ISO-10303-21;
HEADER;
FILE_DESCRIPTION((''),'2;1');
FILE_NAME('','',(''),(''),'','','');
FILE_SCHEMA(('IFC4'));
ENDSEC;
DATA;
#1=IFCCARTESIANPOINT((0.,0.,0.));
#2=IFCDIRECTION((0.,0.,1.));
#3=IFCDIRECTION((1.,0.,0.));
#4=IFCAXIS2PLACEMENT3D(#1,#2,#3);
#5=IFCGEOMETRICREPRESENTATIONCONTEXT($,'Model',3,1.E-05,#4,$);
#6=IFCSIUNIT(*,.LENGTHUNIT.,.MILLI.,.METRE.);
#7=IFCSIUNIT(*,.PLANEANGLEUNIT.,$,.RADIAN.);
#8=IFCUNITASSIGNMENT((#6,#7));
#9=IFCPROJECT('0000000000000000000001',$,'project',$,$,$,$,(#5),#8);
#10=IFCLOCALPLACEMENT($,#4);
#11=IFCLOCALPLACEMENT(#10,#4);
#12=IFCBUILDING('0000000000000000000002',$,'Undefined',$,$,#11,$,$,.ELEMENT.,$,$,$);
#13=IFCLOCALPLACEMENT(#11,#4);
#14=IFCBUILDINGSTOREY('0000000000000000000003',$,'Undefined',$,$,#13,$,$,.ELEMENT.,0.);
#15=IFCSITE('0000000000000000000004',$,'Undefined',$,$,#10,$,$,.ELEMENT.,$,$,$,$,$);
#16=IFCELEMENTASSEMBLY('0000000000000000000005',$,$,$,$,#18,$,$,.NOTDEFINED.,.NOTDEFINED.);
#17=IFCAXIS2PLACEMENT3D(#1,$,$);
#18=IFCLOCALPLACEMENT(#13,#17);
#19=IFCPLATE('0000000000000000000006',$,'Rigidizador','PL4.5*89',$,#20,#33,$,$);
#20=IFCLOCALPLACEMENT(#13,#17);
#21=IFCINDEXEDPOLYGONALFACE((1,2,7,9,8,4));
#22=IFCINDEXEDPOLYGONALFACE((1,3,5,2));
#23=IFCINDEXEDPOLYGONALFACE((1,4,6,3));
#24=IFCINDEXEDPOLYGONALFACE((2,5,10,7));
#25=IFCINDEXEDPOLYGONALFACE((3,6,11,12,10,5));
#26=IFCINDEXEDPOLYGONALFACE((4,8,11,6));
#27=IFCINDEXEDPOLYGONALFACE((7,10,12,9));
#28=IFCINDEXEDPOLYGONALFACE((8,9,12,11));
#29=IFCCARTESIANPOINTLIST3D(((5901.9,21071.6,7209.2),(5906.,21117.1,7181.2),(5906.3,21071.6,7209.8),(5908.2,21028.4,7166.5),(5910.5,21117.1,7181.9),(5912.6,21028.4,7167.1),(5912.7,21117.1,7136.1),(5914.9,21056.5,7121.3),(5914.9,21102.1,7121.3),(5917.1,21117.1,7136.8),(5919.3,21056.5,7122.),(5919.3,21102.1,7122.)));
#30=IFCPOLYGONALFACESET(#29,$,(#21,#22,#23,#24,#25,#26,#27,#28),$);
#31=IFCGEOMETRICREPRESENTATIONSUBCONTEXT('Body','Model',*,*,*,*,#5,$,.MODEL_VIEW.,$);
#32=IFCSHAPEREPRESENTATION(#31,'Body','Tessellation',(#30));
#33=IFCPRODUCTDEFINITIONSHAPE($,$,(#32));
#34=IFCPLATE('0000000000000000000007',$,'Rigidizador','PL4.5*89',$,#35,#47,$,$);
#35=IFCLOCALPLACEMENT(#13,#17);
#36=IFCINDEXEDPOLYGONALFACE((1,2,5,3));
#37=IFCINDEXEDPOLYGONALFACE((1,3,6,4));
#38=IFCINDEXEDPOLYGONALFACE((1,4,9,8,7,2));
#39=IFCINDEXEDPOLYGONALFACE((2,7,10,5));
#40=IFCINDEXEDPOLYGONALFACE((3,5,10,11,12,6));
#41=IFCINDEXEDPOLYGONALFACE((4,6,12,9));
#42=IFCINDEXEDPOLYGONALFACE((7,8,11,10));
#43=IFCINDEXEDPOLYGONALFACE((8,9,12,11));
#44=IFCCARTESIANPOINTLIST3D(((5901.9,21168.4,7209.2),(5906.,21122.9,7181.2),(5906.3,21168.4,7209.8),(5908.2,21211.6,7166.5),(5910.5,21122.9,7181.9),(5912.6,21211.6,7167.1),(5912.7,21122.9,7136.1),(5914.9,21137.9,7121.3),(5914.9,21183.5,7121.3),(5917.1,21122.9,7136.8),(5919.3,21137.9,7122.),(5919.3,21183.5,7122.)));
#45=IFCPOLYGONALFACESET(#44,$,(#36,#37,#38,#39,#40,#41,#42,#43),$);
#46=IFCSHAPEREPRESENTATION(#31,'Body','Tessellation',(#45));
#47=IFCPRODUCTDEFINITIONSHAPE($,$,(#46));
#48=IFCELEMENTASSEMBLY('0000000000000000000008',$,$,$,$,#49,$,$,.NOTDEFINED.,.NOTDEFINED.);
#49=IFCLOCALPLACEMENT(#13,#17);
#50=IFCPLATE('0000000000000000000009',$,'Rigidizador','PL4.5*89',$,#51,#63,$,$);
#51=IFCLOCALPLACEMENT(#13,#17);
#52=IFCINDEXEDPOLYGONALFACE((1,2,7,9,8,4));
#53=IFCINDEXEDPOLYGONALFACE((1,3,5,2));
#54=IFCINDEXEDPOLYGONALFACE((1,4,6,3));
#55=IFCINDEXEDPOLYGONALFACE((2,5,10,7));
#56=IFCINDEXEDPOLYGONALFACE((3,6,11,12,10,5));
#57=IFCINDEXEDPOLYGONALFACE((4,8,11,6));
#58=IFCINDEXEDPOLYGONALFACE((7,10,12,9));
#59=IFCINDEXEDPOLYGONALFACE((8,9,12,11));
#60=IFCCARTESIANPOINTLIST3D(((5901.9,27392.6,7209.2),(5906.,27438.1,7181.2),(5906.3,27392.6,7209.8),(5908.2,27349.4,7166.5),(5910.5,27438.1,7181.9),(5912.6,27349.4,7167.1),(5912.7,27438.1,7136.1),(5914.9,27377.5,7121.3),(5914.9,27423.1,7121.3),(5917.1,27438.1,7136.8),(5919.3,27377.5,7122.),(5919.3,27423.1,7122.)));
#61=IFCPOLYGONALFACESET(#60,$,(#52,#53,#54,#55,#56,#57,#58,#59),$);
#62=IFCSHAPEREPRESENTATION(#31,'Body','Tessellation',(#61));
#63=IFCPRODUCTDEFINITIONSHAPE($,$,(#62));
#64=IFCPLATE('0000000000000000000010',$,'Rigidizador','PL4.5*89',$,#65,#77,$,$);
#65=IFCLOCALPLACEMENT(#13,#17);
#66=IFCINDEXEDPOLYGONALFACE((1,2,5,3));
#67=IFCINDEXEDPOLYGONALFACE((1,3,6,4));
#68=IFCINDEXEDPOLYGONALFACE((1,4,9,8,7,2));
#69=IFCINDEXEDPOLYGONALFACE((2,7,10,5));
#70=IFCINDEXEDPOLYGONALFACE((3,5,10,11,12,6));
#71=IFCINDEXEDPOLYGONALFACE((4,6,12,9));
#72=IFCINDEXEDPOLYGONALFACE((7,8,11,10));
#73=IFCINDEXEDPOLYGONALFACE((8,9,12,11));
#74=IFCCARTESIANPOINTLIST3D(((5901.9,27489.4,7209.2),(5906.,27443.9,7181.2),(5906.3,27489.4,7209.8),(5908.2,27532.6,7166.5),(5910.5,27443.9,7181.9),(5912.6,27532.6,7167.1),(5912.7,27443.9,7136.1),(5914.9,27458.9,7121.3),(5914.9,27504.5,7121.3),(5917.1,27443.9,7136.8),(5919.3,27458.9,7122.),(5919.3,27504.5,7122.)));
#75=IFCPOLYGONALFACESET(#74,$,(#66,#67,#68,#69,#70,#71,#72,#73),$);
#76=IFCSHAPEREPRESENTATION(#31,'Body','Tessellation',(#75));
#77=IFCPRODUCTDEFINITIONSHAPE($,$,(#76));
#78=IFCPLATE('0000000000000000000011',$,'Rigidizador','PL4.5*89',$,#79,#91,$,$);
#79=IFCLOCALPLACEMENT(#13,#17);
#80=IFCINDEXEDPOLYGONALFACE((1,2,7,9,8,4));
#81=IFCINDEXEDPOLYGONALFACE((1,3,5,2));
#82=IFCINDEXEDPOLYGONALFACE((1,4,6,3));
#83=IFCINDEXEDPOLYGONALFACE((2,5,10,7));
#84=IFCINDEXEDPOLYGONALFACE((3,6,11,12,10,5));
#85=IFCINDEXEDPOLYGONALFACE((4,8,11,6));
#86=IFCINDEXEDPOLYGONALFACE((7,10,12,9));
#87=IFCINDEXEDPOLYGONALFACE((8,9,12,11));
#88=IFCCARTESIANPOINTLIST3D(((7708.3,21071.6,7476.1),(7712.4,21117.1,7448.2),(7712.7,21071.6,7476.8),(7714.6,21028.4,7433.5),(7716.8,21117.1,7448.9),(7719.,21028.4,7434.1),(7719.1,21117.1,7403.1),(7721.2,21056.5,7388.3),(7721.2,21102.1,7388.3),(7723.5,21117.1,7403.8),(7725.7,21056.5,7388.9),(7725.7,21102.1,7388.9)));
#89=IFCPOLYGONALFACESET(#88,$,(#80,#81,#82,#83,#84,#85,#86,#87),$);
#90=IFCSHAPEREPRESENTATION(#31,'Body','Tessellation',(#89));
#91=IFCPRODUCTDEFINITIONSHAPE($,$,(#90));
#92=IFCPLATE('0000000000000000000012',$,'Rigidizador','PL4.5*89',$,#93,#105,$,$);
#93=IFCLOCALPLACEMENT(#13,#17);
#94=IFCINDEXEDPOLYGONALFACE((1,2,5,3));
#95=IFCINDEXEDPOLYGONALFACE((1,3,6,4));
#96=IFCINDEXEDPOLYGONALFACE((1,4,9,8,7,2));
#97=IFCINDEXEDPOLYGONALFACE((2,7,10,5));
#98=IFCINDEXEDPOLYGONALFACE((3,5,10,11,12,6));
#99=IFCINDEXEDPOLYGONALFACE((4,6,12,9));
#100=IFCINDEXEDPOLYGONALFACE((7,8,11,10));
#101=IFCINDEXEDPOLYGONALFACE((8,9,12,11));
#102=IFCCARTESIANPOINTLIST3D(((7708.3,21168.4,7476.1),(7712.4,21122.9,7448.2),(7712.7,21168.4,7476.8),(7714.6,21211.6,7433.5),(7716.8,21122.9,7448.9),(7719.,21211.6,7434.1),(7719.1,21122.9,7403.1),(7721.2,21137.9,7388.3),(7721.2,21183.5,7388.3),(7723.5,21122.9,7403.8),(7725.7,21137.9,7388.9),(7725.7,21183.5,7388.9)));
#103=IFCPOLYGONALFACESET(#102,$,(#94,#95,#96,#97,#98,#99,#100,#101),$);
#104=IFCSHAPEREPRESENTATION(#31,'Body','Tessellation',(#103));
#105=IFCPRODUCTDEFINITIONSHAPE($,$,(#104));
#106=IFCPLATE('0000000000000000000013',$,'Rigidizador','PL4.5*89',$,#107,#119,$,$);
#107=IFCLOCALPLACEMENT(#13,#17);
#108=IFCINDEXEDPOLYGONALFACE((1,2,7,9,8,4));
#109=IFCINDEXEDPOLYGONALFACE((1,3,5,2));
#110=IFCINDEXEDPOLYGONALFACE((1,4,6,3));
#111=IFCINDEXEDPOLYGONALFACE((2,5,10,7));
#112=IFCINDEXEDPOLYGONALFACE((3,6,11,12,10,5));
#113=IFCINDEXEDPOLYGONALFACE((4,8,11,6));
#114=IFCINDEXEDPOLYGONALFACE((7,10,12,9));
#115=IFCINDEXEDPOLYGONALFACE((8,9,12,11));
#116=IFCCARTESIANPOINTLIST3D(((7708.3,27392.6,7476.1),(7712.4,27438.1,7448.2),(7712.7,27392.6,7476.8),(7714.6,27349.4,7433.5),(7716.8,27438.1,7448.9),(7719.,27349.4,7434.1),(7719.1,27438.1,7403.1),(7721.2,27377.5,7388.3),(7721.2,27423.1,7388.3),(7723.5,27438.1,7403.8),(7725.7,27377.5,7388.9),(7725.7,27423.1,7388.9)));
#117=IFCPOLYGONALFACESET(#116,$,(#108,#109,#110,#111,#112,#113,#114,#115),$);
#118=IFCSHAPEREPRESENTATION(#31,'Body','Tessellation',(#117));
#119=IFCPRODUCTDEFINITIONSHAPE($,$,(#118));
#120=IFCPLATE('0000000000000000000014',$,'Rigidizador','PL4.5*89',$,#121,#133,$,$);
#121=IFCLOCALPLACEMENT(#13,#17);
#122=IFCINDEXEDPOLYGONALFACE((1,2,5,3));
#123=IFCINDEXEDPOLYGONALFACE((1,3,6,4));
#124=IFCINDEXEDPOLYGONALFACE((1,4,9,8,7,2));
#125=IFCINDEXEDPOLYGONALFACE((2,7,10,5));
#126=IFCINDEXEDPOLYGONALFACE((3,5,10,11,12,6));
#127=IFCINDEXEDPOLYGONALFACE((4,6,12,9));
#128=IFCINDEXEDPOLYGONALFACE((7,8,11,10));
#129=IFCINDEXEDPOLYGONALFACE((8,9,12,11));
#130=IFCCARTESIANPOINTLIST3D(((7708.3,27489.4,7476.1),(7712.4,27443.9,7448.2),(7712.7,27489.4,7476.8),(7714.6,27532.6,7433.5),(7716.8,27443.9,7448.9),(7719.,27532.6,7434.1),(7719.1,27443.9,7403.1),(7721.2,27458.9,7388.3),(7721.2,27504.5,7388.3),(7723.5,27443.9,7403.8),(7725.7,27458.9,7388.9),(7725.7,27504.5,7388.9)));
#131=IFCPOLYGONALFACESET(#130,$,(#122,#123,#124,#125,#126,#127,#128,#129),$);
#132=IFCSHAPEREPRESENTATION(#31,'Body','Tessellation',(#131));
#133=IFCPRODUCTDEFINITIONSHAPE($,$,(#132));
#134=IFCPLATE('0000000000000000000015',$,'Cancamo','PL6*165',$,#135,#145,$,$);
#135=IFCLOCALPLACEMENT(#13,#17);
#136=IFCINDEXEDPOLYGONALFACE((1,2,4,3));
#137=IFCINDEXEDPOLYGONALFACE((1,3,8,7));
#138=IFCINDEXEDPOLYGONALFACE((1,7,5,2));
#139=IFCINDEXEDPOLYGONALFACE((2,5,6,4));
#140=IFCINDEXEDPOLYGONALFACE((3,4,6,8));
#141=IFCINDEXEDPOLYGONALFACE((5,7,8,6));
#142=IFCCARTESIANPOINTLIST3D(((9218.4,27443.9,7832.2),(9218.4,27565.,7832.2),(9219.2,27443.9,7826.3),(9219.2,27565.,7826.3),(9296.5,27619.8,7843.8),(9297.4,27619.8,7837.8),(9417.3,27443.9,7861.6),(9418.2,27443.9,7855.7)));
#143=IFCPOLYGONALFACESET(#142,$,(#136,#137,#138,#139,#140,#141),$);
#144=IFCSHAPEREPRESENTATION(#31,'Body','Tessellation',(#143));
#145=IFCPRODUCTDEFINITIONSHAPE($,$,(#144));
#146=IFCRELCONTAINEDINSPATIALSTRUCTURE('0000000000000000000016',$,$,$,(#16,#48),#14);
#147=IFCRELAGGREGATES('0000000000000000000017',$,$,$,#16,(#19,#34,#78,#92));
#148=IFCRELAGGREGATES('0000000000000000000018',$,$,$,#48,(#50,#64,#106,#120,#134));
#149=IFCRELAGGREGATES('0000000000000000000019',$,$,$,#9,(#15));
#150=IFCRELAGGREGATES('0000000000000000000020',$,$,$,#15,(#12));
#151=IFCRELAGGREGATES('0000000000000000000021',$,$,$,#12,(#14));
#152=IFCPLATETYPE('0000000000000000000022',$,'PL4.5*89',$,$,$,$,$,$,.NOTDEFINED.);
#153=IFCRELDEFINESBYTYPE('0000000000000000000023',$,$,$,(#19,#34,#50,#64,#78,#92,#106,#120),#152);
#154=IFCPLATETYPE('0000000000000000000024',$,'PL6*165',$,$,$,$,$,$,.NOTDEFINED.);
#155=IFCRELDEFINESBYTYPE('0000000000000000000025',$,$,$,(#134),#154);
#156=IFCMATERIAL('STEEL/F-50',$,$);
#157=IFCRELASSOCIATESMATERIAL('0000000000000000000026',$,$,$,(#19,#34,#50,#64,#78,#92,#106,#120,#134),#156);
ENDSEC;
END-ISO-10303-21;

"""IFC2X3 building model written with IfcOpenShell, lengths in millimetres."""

from ifc_helpers import new_model, si_unit, frame, origin_with_axes, place, context, subcontext, project, spatial, polyline, outline, extrude, material, type_object, element, aggregate, save


model = new_model("IFC2X3")

# Units and contexts
model_context = context("Model", 3, precision=1e-05, world=origin_with_axes())
body_context = subcontext(model_context, "Body", "Model", "MODEL_VIEW")
ifc_project = project(units=[si_unit("LENGTHUNIT", "METRE", prefix="MILLI"), si_unit("PLANEANGLEUNIT", "RADIAN")], contexts=[model_context])

# Site, building, storey
site_placement = place(None, origin_with_axes())
site = spatial("IfcSite", under=ifc_project, at=site_placement, Name="Undefined", CompositionType="ELEMENT")
building_placement = place(site_placement, origin_with_axes())
building = spatial("IfcBuilding", under=site, at=building_placement, Name="Undefined", CompositionType="ELEMENT")
storey_placement = place(building_placement, origin_with_axes())
storey = spatial("IfcBuildingStorey", under=building, at=storey_placement, Name="Undefined", CompositionType="ELEMENT", Elevation=0.0)

# Element assemblies, plates
assembly_1_placement = place(storey_placement, origin_with_axes())
assembly_1 = element("IfcElementAssembly", 1, at=assembly_1_placement, inside=storey, AssemblyPlace="NOTDEFINED", PredefinedType="NOTDEFINED")
ifc_material_1 = material(Name="STEEL/F-50")
plate_type_1 = type_object("IfcPlateType", Name="PL4.5*89", PredefinedType="NOTDEFINED")
plate_1_placement = place(assembly_1_placement, frame((5917.1, 21056.5, 7121.6), z_axis=(0.989255, 0.0, 0.146202), x_axis=(0.0, 1.0, 0.0)))
plate_1 = element("IfcPlate", 2, at=plate_1_placement, type_object=plate_type_1, material=ifc_material_1, Name="Rigidizador", Description="PL4.5*89", context=body_context, shape_type="SweptSolid", body=[
    extrude(outline(polyline([(0.0, 0.0), (45.6, 0.0), (60.6, 15.0), (60.6, 60.6), (15.1, 88.8), (-28.1, 45.7), (0.0, 0.0)])), frame((0.0, 0.0, -2.2), z_axis=(0.0, 0.0, 1.0), x_axis=(1.0, 0.0, 0.0)), (0.0, 0.0, 1.0), 4.5),
])
plate_2_placement = place(assembly_1_placement, frame((5917.1, 21183.5, 7121.6), z_axis=(-0.989255, 0.0, -0.146202), x_axis=(0.0, -1.0, 0.0)))
plate_2 = element("IfcPlate", 3, at=plate_2_placement, type_object=plate_type_1, material=ifc_material_1, Name="Rigidizador", Description="PL4.5*89", context=body_context, shape_type="SweptSolid", body=[
    extrude(outline(polyline([(0.0, 0.0), (45.6, 0.0), (60.6, 15.0), (60.6, 60.6), (15.1, 88.8), (-28.1, 45.7), (0.0, 0.0)])), frame((0.0, 0.0, -2.2), z_axis=(0.0, 0.0, 1.0), x_axis=(1.0, 0.0, 0.0)), (0.0, 0.0, 1.0), 4.5),
])
assembly_2_placement = place(storey_placement, origin_with_axes())
assembly_2 = element("IfcElementAssembly", 4, at=assembly_2_placement, inside=storey, AssemblyPlace="NOTDEFINED", PredefinedType="NOTDEFINED")
plate_3_placement = place(assembly_2_placement, frame((5917.1, 27377.5, 7121.6), z_axis=(0.989255, 0.0, 0.146202), x_axis=(0.0, 1.0, 0.0)))
plate_3 = element("IfcPlate", 5, at=plate_3_placement, type_object=plate_type_1, material=ifc_material_1, Name="Rigidizador", Description="PL4.5*89", context=body_context, shape_type="SweptSolid", body=[
    extrude(outline(polyline([(0.0, 0.0), (45.6, 0.0), (60.6, 15.0), (60.6, 60.6), (15.1, 88.8), (-28.1, 45.7), (0.0, 0.0)])), frame((0.0, 0.0, -2.2), z_axis=(0.0, 0.0, 1.0), x_axis=(1.0, 0.0, 0.0)), (0.0, 0.0, 1.0), 4.5),
])
plate_4_placement = place(assembly_2_placement, frame((5917.1, 27504.5, 7121.6), z_axis=(-0.989255, 0.0, -0.146202), x_axis=(0.0, -1.0, 0.0)))
plate_4 = element("IfcPlate", 6, at=plate_4_placement, type_object=plate_type_1, material=ifc_material_1, Name="Rigidizador", Description="PL4.5*89", context=body_context, shape_type="SweptSolid", body=[
    extrude(outline(polyline([(0.0, 0.0), (45.6, 0.0), (60.6, 15.0), (60.6, 60.6), (15.1, 88.8), (-28.1, 45.7), (0.0, 0.0)])), frame((0.0, 0.0, -2.2), z_axis=(0.0, 0.0, 1.0), x_axis=(1.0, 0.0, 0.0)), (0.0, 0.0, 1.0), 4.5),
])

# Plates
plate_5_placement = place(assembly_1_placement, frame((7723.5, 21056.5, 7388.6), z_axis=(0.989255, 0.0, 0.146202), x_axis=(0.0, 1.0, 0.0)))
plate_5 = element("IfcPlate", 7, at=plate_5_placement, type_object=plate_type_1, material=ifc_material_1, Name="Rigidizador", Description="PL4.5*89", context=body_context, shape_type="SweptSolid", body=[
    extrude(outline(polyline([(0.0, 0.0), (45.6, 0.0), (60.6, 15.0), (60.6, 60.6), (15.1, 88.8), (-28.1, 45.7), (0.0, 0.0)])), frame((0.0, 0.0, -2.2), z_axis=(0.0, 0.0, 1.0), x_axis=(1.0, 0.0, 0.0)), (0.0, 0.0, 1.0), 4.5),
])
plate_6_placement = place(assembly_1_placement, frame((7723.5, 21183.5, 7388.6), z_axis=(-0.989255, 0.0, -0.146202), x_axis=(0.0, -1.0, 0.0)))
plate_6 = element("IfcPlate", 8, at=plate_6_placement, type_object=plate_type_1, material=ifc_material_1, Name="Rigidizador", Description="PL4.5*89", context=body_context, shape_type="SweptSolid", body=[
    extrude(outline(polyline([(0.0, 0.0), (45.6, 0.0), (60.6, 15.0), (60.6, 60.6), (15.1, 88.8), (-28.1, 45.7), (0.0, 0.0)])), frame((0.0, 0.0, -2.2), z_axis=(0.0, 0.0, 1.0), x_axis=(1.0, 0.0, 0.0)), (0.0, 0.0, 1.0), 4.5),
])
plate_7_placement = place(assembly_2_placement, frame((7723.5, 27377.5, 7388.6), z_axis=(0.989255, 0.0, 0.146202), x_axis=(0.0, 1.0, 0.0)))
plate_7 = element("IfcPlate", 9, at=plate_7_placement, type_object=plate_type_1, material=ifc_material_1, Name="Rigidizador", Description="PL4.5*89", context=body_context, shape_type="SweptSolid", body=[
    extrude(outline(polyline([(0.0, 0.0), (45.6, 0.0), (60.6, 15.0), (60.6, 60.6), (15.1, 88.8), (-28.1, 45.7), (0.0, 0.0)])), frame((0.0, 0.0, -2.2), z_axis=(0.0, 0.0, 1.0), x_axis=(1.0, 0.0, 0.0)), (0.0, 0.0, 1.0), 4.5),
])
plate_8_placement = place(assembly_2_placement, frame((7723.5, 27504.5, 7388.6), z_axis=(-0.989255, 0.0, -0.146202), x_axis=(0.0, -1.0, 0.0)))
plate_8 = element("IfcPlate", 10, at=plate_8_placement, type_object=plate_type_1, material=ifc_material_1, Name="Rigidizador", Description="PL4.5*89", context=body_context, shape_type="SweptSolid", body=[
    extrude(outline(polyline([(0.0, 0.0), (45.6, 0.0), (60.6, 15.0), (60.6, 60.6), (15.1, 88.8), (-28.1, 45.7), (0.0, 0.0)])), frame((0.0, 0.0, -2.2), z_axis=(0.0, 0.0, 1.0), x_axis=(1.0, 0.0, 0.0)), (0.0, 0.0, 1.0), 4.5),
])
plate_type_2 = type_object("IfcPlateType", Name="PL6*165", PredefinedType="NOTDEFINED")
plate_9_placement = place(assembly_2_placement, frame((9218.8, 27443.9, 7829.2), z_axis=(-0.146202, 0.0, 0.989255), x_axis=(0.989255, 0.0, 0.146202)))
plate_9 = element("IfcPlate", 11, at=plate_9_placement, type_object=plate_type_2, material=ifc_material_1, Name="Cancamo", Description="PL6*165", context=body_context, shape_type="SweptSolid", body=[
    extrude(outline(polyline([(0.0, 0.0), (201.1, 0.0), (79.0, 175.9), (0.0, 121.1), (0.0, 0.0)])), frame((0.0, 0.0, -3.0), z_axis=(0.0, 0.0, 1.0), x_axis=(1.0, 0.0, 0.0)), (0.0, 0.0, 1.0), 6.0),
])

aggregate(assembly_1, [plate_1, plate_2, plate_5, plate_6])
aggregate(assembly_2, [plate_3, plate_4, plate_7, plate_8, plate_9])

save(model, "model.ifc")
